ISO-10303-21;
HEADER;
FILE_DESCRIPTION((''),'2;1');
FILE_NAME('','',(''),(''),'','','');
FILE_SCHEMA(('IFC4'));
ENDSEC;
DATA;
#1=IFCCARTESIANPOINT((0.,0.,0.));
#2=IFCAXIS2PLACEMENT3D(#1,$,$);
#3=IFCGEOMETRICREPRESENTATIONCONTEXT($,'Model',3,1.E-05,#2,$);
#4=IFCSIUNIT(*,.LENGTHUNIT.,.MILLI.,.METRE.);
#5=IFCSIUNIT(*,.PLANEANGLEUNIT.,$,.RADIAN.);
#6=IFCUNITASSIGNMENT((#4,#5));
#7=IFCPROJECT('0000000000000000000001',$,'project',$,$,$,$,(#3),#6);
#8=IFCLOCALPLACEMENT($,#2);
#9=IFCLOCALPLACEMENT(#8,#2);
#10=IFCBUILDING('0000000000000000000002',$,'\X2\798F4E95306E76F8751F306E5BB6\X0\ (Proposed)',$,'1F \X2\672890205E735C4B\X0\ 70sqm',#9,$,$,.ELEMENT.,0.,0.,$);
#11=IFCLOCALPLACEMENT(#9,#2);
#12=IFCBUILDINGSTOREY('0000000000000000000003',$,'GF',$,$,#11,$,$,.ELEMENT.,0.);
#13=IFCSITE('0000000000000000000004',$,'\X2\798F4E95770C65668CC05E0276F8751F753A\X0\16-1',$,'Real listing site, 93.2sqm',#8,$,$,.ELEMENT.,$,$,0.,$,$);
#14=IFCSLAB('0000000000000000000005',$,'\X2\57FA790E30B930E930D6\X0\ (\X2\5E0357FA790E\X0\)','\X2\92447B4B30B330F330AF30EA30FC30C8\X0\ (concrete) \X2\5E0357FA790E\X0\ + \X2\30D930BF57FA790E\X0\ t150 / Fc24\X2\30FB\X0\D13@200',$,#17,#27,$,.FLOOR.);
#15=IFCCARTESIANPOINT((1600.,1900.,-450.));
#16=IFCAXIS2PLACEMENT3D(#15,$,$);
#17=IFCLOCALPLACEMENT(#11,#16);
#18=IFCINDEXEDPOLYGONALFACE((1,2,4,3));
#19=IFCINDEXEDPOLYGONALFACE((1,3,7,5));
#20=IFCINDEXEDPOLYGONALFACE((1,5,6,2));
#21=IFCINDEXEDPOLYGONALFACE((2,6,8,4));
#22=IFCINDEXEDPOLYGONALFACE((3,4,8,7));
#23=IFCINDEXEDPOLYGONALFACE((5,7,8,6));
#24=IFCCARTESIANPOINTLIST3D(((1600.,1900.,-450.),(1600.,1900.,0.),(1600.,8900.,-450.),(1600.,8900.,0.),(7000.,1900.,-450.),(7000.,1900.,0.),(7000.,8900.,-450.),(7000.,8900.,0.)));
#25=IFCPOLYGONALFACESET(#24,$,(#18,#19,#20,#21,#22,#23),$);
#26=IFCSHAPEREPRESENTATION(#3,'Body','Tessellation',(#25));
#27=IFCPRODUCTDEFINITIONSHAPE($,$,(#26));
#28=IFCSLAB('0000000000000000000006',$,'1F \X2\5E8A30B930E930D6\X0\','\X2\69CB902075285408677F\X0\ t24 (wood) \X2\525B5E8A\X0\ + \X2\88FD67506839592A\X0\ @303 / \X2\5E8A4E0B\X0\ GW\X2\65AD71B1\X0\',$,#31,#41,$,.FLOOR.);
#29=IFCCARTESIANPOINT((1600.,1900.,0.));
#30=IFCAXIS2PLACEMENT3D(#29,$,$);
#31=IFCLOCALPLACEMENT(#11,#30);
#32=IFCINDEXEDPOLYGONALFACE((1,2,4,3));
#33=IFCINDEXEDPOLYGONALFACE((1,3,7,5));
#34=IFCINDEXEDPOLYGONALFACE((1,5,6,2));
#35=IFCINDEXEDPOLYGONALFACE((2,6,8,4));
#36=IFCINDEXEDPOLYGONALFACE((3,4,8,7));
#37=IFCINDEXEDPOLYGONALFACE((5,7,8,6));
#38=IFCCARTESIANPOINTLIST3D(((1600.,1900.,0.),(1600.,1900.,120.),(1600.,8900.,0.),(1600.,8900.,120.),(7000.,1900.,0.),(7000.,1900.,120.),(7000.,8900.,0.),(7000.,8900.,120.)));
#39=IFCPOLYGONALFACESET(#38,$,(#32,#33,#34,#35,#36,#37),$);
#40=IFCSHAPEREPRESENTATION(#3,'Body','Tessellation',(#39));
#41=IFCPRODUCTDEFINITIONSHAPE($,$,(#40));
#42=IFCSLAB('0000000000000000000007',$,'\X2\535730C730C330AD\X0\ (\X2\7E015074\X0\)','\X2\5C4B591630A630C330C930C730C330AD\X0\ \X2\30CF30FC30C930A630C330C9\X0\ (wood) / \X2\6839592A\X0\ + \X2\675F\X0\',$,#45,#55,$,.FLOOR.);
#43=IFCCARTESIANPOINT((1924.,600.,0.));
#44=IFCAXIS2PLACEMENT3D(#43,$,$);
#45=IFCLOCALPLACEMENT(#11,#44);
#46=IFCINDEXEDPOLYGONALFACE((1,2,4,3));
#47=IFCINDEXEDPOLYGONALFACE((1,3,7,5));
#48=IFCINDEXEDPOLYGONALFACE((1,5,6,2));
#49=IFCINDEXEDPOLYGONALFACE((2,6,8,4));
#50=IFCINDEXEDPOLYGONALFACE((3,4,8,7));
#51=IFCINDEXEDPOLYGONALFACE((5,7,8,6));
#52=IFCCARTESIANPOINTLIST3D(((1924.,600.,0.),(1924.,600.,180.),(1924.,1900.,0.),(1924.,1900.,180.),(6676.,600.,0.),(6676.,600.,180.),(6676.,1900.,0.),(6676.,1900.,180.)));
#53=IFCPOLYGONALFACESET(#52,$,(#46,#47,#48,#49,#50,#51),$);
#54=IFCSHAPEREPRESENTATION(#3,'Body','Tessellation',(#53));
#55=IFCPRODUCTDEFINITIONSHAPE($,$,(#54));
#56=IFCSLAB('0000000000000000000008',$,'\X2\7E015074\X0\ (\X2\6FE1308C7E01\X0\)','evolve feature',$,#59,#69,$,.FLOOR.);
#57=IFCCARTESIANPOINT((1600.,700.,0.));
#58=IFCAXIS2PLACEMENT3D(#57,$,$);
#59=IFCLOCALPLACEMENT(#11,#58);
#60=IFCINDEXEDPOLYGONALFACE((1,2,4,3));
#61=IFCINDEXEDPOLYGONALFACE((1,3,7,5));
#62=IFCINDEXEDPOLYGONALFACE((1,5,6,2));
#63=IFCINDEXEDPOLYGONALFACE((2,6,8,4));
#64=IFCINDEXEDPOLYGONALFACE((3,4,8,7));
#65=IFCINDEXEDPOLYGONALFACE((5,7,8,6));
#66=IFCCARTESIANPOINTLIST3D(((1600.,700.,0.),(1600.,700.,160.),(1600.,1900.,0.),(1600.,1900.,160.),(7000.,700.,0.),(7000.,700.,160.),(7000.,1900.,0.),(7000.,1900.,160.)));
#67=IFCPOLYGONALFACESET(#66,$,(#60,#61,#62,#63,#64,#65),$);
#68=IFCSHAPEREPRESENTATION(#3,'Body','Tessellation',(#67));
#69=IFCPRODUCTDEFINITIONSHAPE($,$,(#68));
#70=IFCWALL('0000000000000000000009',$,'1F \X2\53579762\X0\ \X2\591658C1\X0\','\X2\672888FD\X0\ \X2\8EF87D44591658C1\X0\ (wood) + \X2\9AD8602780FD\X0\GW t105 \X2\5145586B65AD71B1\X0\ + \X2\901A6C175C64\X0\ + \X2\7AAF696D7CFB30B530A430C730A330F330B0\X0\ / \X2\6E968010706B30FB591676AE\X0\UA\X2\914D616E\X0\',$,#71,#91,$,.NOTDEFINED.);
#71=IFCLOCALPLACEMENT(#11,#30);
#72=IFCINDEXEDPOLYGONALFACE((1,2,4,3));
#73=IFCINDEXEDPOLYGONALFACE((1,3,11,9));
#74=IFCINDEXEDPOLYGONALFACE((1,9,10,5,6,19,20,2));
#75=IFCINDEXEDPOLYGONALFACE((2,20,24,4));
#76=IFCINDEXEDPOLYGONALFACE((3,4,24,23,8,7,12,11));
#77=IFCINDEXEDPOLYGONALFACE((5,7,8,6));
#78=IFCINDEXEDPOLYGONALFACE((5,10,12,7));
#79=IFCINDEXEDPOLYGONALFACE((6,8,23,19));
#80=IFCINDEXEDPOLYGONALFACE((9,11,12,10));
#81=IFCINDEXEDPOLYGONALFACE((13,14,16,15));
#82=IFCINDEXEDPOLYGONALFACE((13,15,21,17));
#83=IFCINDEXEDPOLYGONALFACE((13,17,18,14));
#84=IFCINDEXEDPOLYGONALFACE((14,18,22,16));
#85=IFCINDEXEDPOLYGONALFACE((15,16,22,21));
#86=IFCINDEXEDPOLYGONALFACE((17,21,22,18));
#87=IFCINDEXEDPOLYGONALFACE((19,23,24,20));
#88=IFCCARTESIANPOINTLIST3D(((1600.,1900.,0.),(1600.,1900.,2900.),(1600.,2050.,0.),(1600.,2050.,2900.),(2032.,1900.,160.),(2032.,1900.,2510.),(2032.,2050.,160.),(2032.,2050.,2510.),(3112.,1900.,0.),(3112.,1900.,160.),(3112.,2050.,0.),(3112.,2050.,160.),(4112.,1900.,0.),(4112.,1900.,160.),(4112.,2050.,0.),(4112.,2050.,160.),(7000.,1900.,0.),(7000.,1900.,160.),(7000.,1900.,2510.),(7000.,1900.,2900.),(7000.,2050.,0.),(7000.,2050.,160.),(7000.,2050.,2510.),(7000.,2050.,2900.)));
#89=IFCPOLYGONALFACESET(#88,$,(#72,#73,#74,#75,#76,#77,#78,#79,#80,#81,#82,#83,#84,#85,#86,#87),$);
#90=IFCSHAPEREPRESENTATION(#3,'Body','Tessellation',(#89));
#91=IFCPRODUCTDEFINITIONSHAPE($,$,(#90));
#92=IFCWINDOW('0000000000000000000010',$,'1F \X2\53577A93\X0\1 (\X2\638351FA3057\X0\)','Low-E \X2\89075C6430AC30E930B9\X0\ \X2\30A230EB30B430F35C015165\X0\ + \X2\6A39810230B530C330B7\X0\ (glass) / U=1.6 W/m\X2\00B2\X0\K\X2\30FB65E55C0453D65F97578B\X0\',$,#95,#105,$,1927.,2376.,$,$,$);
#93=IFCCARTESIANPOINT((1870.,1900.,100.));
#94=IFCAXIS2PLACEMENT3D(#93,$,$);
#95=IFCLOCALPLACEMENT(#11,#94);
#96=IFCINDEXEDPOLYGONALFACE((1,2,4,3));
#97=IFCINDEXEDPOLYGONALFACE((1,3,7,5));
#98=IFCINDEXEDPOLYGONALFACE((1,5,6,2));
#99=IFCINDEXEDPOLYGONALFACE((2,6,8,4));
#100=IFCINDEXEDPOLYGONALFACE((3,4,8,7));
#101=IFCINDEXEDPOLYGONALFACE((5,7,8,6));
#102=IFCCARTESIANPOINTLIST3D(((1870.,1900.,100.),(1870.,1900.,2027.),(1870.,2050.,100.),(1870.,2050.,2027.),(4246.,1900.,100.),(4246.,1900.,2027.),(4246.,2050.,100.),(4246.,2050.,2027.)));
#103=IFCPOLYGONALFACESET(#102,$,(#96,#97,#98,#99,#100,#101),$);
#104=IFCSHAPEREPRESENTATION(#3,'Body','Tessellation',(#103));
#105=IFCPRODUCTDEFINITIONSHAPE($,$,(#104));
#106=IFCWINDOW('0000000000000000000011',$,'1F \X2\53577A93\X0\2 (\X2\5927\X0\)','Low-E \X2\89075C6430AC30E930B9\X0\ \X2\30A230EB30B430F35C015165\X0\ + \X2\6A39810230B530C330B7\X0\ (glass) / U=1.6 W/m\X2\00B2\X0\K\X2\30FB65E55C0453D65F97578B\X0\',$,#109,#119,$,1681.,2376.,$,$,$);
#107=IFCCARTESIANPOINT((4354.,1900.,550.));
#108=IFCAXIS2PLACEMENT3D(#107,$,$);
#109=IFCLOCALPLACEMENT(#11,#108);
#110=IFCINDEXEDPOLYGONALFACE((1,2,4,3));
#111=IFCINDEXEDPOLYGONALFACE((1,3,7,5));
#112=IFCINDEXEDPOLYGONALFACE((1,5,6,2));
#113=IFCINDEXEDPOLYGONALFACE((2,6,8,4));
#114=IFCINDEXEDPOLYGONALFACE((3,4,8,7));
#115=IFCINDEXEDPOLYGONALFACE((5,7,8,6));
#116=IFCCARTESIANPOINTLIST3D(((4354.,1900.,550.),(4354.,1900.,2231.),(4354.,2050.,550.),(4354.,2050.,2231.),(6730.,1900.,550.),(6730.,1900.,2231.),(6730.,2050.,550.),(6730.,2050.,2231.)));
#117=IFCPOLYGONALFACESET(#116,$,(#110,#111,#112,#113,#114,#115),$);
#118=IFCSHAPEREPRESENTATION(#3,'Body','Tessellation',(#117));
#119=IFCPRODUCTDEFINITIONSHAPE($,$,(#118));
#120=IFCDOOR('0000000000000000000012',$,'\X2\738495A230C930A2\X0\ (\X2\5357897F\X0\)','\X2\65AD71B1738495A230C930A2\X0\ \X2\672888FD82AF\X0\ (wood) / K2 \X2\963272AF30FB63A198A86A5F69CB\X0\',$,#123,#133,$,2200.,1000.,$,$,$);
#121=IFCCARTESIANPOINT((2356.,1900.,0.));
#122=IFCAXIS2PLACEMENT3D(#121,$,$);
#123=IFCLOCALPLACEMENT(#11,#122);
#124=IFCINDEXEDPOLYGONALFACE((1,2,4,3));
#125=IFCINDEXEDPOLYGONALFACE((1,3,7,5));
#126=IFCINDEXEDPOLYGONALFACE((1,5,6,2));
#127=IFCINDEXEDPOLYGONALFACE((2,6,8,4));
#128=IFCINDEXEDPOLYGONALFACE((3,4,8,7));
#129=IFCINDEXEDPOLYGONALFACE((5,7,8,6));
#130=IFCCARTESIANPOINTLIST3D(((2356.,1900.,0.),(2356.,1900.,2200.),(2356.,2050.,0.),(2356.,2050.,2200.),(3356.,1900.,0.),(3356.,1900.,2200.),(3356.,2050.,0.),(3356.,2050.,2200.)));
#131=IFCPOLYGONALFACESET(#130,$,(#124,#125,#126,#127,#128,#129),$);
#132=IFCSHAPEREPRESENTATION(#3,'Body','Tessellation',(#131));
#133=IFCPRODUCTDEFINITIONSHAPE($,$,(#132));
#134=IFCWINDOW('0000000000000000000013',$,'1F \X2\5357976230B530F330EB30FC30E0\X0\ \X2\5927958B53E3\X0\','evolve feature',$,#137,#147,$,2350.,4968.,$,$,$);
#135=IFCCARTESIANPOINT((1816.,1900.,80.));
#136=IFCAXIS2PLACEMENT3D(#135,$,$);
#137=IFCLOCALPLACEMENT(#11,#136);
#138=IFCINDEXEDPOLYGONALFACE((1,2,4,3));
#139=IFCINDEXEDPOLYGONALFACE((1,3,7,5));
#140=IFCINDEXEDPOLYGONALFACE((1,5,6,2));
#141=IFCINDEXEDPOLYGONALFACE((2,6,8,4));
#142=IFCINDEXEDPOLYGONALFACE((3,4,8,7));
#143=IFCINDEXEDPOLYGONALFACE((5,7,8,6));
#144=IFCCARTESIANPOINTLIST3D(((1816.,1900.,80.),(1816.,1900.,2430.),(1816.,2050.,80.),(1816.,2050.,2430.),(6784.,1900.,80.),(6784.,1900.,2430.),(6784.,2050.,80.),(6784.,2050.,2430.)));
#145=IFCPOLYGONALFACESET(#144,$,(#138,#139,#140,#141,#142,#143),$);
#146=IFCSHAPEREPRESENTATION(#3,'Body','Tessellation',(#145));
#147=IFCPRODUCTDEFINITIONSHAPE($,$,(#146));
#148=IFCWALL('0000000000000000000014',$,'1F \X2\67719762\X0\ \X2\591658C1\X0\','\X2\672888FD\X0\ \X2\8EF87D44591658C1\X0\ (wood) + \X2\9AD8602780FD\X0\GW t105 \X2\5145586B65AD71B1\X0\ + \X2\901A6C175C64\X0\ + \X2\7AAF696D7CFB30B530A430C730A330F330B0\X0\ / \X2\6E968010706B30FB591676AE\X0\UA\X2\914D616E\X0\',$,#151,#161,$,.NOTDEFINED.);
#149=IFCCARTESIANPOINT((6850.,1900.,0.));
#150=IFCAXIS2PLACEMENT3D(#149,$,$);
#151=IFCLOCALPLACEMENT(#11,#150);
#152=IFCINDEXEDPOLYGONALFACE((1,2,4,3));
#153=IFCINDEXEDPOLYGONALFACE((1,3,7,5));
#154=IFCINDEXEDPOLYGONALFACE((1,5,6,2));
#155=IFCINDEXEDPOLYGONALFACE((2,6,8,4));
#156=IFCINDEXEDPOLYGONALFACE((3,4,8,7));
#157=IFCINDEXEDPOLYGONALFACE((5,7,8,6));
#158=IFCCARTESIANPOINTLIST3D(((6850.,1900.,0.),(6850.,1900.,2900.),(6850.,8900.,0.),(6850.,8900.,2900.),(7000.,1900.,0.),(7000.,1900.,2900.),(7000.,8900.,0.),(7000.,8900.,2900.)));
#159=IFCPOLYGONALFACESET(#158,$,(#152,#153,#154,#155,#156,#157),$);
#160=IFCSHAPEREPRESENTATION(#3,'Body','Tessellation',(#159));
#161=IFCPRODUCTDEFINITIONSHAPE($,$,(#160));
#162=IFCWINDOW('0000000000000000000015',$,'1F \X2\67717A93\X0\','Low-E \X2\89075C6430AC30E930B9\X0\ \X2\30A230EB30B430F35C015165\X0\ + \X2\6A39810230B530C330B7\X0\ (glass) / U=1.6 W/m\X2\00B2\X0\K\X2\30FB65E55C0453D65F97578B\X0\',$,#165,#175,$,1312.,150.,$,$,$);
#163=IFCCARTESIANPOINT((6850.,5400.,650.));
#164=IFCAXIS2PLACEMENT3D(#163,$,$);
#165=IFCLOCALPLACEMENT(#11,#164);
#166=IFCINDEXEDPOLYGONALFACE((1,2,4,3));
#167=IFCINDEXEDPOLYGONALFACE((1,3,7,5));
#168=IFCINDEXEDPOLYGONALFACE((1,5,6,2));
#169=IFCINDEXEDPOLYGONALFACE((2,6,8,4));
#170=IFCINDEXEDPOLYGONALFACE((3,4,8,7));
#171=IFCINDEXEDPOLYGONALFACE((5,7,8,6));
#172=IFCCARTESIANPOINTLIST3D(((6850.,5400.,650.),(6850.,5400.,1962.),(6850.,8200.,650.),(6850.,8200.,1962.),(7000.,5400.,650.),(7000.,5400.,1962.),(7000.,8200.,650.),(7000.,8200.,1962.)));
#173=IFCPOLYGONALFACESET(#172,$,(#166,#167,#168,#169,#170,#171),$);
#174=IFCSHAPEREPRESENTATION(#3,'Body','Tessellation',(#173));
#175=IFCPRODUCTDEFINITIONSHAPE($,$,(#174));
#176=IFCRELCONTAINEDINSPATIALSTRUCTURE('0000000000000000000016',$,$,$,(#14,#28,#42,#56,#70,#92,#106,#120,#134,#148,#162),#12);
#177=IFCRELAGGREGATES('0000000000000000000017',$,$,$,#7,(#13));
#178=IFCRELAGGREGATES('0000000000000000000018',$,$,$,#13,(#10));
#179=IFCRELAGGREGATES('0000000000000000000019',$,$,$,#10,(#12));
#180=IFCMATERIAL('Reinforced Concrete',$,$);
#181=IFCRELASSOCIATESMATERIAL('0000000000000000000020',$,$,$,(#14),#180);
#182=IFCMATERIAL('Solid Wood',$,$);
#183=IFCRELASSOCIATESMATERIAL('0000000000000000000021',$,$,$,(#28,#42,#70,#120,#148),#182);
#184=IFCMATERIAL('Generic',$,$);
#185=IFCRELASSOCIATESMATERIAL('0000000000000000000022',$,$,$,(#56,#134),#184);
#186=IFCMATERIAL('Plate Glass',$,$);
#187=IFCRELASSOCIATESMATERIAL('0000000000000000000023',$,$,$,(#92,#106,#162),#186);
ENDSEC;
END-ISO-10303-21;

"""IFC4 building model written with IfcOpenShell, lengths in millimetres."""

from ifc_helpers import new_model, si_unit, frame, frame_2d, origin, place, context, project, spatial, rectangle, extrude, material, element, fill, save


model = new_model("IFC4")

# Units and contexts
model_context = context("Model", 3, precision=1e-05, world=origin())
ifc_project = project(units=[si_unit("LENGTHUNIT", "METRE", prefix="MILLI"), si_unit("PLANEANGLEUNIT", "RADIAN")], contexts=[model_context])

# Site, building, storey
site_placement = place(None, origin())
site = spatial("IfcSite", under=ifc_project, at=site_placement, Name="福井県敦賀市相生町16-1", ObjectType="Real listing site, 93.2sqm", CompositionType="ELEMENT", RefElevation=0.0)
building_placement = place(site_placement, origin())
building = spatial("IfcBuilding", under=site, at=building_placement, Name="福井の相生の家 (Proposed)", ObjectType="1F 木造平屋 70sqm", CompositionType="ELEMENT", ElevationOfRefHeight=0.0, ElevationOfTerrain=0.0)
storey_placement = place(building_placement, origin())
storey = spatial("IfcBuildingStorey", under=building, at=storey_placement, Name="GF", CompositionType="ELEMENT", Elevation=0.0)

# Slabs
ifc_material_1 = material(Name="Reinforced Concrete")
slab_1_placement = place(storey_placement, frame((1600.0, 1900.0, -450.0)))
element("IfcSlab", 1, at=slab_1_placement, inside=storey, material=ifc_material_1, Name="基礎スラブ (布基礎)", Description="鉄筋コンクリート (concrete) 布基礎 + ベタ基礎 t150 / Fc24・D13@200", PredefinedType="FLOOR", context=model_context, shape_type="SweptSolid", body=[
    extrude(rectangle(XDim=5400.0, YDim=7000.0, at=frame_2d((2700.0, 3500.0))), frame((1600.0, 1900.0, -450.0)), (0.0, 0.0, 1.0), 450.0),
])
ifc_material_2 = material(Name="Solid Wood")
slab_2_placement = place(storey_placement, frame((1600.0, 1900.0, 0.0)))
element("IfcSlab", 2, at=slab_2_placement, inside=storey, material=ifc_material_2, Name="1F 床スラブ", Description="構造用合板 t24 (wood) 剛床 + 製材根太 @303 / 床下 GW断熱", PredefinedType="FLOOR", context=model_context, shape_type="SweptSolid", body=[
    extrude(rectangle(XDim=5400.0, YDim=7000.0, at=frame_2d((2700.0, 3500.0))), frame((1600.0, 1900.0, 0.0)), (0.0, 0.0, 1.0), 120.0),
])
slab_3_placement = place(storey_placement, frame((1924.0, 600.0, 0.0)))
element("IfcSlab", 3, at=slab_3_placement, inside=storey, material=ifc_material_2, Name="南デッキ (縁側)", Description="屋外ウッドデッキ ハードウッド (wood) / 根太 + 束", PredefinedType="FLOOR", context=model_context, shape_type="SweptSolid", body=[
    extrude(rectangle(XDim=4752.0, YDim=1300.0, at=frame_2d((2376.0, 650.0))), frame((1924.0, 600.0, 0.0)), (0.0, 0.0, 1.0), 180.0),
])
ifc_material_3 = material(Name="Generic")
slab_4_placement = place(storey_placement, frame((1600.0, 700.0, 0.0)))
element("IfcSlab", 4, at=slab_4_placement, inside=storey, material=ifc_material_3, Name="縁側 (濡れ縁)", Description="evolve feature", PredefinedType="FLOOR", context=model_context, shape_type="SweptSolid", body=[
    extrude(rectangle(XDim=5400.0, YDim=1200.0, at=frame_2d((2700.0, 600.0))), frame((1600.0, 700.0, 0.0)), (0.0, 0.0, 1.0), 160.0),
])

# Wall, openings, windows, door
wall_1_placement = place(storey_placement, frame((1600.0, 1900.0, 0.0)))
wall_1 = element("IfcWall", 5, at=wall_1_placement, inside=storey, material=ifc_material_2, Name="1F 南面 外壁", Description="木製 軸組外壁 (wood) + 高性能GW t105 充填断熱 + 通気層 + 窯業系サイディング / 準耐火・外皮UA配慮", PredefinedType="NOTDEFINED", context=model_context, shape_type="SweptSolid", body=[
    extrude(rectangle(XDim=5400.0, YDim=150.0, at=frame_2d((2700.0, 75.0))), frame((1600.0, 1900.0, 0.0)), (0.0, 0.0, 1.0), 2900.0),
])
opening_1_placement = place(storey_placement, frame((1870.0, 1900.0, 100.0)))
opening_1 = element("IfcOpeningElement", 6, at=opening_1_placement, cuts=wall_1, PredefinedType="NOTDEFINED", context=model_context, shape_type="SweptSolid", body=[
    extrude(rectangle(XDim=2376.0, YDim=150.0, at=frame_2d((1188.0, 75.0))), frame((1870.0, 1900.0, 100.0)), (0.0, 0.0, 1.0), 1927.0),
])
opening_2_placement = place(storey_placement, frame((4354.0, 1900.0, 550.0)))
opening_2 = element("IfcOpeningElement", 7, at=opening_2_placement, cuts=wall_1, PredefinedType="NOTDEFINED", context=model_context, shape_type="SweptSolid", body=[
    extrude(rectangle(XDim=2376.0, YDim=150.0, at=frame_2d((1188.0, 75.0))), frame((4354.0, 1900.0, 550.0)), (0.0, 0.0, 1.0), 1681.0),
])
opening_3_placement = place(storey_placement, frame((2356.0, 1900.0, 0.0)))
opening_3 = element("IfcOpeningElement", 8, at=opening_3_placement, cuts=wall_1, PredefinedType="NOTDEFINED", context=model_context, shape_type="SweptSolid", body=[
    extrude(rectangle(XDim=1000.0, YDim=150.0, at=frame_2d((500.0, 75.0))), frame((2356.0, 1900.0, 0.0)), (0.0, 0.0, 1.0), 2200.0),
])
opening_4_placement = place(storey_placement, frame((1816.0, 1900.0, 80.0)))
opening_4 = element("IfcOpeningElement", 9, at=opening_4_placement, cuts=wall_1, PredefinedType="NOTDEFINED", context=model_context, shape_type="SweptSolid", body=[
    extrude(rectangle(XDim=4968.0, YDim=150.0, at=frame_2d((2484.0, 75.0))), frame((1816.0, 1900.0, 80.0)), (0.0, 0.0, 1.0), 2350.0),
])
ifc_material_4 = material(Name="Plate Glass")
window_1_placement = place(storey_placement, frame((1870.0, 1900.0, 100.0)))
window_1 = element("IfcWindow", 10, at=window_1_placement, inside=storey, material=ifc_material_4, Name="1F 南窓1 (掃出し)", Description="Low-E 複層ガラス アルゴン封入 + 樹脂サッシ (glass) / U=1.6 W/m²K・日射取得型", OverallHeight=1927.0, OverallWidth=2376.0, context=model_context, shape_type="SweptSolid", body=[
    extrude(rectangle(XDim=2376.0, YDim=150.0, at=frame_2d((1188.0, 75.0))), frame((1870.0, 1900.0, 100.0)), (0.0, 0.0, 1.0), 1927.0),
])
fill(opening_1, window_1)
window_2_placement = place(storey_placement, frame((4354.0, 1900.0, 550.0)))
window_2 = element("IfcWindow", 11, at=window_2_placement, inside=storey, material=ifc_material_4, Name="1F 南窓2 (大)", Description="Low-E 複層ガラス アルゴン封入 + 樹脂サッシ (glass) / U=1.6 W/m²K・日射取得型", OverallHeight=1681.0, OverallWidth=2376.0, context=model_context, shape_type="SweptSolid", body=[
    extrude(rectangle(XDim=2376.0, YDim=150.0, at=frame_2d((1188.0, 75.0))), frame((4354.0, 1900.0, 550.0)), (0.0, 0.0, 1.0), 1681.0),
])
fill(opening_2, window_2)
door_placement = place(storey_placement, frame((2356.0, 1900.0, 0.0)))
door = element("IfcDoor", 12, at=door_placement, inside=storey, material=ifc_material_2, Name="玄関ドア (南西)", Description="断熱玄関ドア 木製芯 (wood) / K2 防犯・採風機構", OverallHeight=2200.0, OverallWidth=1000.0, context=model_context, shape_type="SweptSolid", body=[
    extrude(rectangle(XDim=1000.0, YDim=150.0, at=frame_2d((500.0, 75.0))), frame((2356.0, 1900.0, 0.0)), (0.0, 0.0, 1.0), 2200.0),
])
fill(opening_3, door)
window_3_placement = place(storey_placement, frame((1816.0, 1900.0, 80.0)))
window_3 = element("IfcWindow", 13, at=window_3_placement, inside=storey, material=ifc_material_3, Name="1F 南面サンルーム 大開口", Description="evolve feature", OverallHeight=2350.0, OverallWidth=4968.0, context=model_context, shape_type="SweptSolid", body=[
    extrude(rectangle(XDim=4968.0, YDim=150.0, at=frame_2d((2484.0, 75.0))), frame((1816.0, 1900.0, 80.0)), (0.0, 0.0, 1.0), 2350.0),
])
fill(opening_4, window_3)

# Wall, opening, window
wall_2_placement = place(storey_placement, frame((6850.0, 1900.0, 0.0)))
wall_2 = element("IfcWall", 14, at=wall_2_placement, inside=storey, material=ifc_material_2, Name="1F 東面 外壁", Description="木製 軸組外壁 (wood) + 高性能GW t105 充填断熱 + 通気層 + 窯業系サイディング / 準耐火・外皮UA配慮", PredefinedType="NOTDEFINED", context=model_context, shape_type="SweptSolid", body=[
    extrude(rectangle(XDim=150.0, YDim=7000.0, at=frame_2d((75.0, 3500.0))), frame((6850.0, 1900.0, 0.0)), (0.0, 0.0, 1.0), 2900.0),
])
opening_5_placement = place(storey_placement, frame((6850.0, 5400.0, 650.0)))
opening_5 = element("IfcOpeningElement", 15, at=opening_5_placement, cuts=wall_2, PredefinedType="NOTDEFINED", context=model_context, shape_type="SweptSolid", body=[
    extrude(rectangle(XDim=150.0, YDim=2800.0, at=frame_2d((75.0, 1400.0))), frame((6850.0, 5400.0, 650.0)), (0.0, 0.0, 1.0), 1312.0),
])
window_4_placement = place(storey_placement, frame((6850.0, 5400.0, 650.0)))
window_4 = element("IfcWindow", 16, at=window_4_placement, inside=storey, material=ifc_material_4, Name="1F 東窓", Description="Low-E 複層ガラス アルゴン封入 + 樹脂サッシ (glass) / U=1.6 W/m²K・日射取得型", OverallHeight=1312.0, OverallWidth=150.0, context=model_context, shape_type="SweptSolid", body=[
    extrude(rectangle(XDim=150.0, YDim=2800.0, at=frame_2d((75.0, 1400.0))), frame((6850.0, 5400.0, 650.0)), (0.0, 0.0, 1.0), 1312.0),
])
fill(opening_5, window_4)

save(model, "model.ifc")
